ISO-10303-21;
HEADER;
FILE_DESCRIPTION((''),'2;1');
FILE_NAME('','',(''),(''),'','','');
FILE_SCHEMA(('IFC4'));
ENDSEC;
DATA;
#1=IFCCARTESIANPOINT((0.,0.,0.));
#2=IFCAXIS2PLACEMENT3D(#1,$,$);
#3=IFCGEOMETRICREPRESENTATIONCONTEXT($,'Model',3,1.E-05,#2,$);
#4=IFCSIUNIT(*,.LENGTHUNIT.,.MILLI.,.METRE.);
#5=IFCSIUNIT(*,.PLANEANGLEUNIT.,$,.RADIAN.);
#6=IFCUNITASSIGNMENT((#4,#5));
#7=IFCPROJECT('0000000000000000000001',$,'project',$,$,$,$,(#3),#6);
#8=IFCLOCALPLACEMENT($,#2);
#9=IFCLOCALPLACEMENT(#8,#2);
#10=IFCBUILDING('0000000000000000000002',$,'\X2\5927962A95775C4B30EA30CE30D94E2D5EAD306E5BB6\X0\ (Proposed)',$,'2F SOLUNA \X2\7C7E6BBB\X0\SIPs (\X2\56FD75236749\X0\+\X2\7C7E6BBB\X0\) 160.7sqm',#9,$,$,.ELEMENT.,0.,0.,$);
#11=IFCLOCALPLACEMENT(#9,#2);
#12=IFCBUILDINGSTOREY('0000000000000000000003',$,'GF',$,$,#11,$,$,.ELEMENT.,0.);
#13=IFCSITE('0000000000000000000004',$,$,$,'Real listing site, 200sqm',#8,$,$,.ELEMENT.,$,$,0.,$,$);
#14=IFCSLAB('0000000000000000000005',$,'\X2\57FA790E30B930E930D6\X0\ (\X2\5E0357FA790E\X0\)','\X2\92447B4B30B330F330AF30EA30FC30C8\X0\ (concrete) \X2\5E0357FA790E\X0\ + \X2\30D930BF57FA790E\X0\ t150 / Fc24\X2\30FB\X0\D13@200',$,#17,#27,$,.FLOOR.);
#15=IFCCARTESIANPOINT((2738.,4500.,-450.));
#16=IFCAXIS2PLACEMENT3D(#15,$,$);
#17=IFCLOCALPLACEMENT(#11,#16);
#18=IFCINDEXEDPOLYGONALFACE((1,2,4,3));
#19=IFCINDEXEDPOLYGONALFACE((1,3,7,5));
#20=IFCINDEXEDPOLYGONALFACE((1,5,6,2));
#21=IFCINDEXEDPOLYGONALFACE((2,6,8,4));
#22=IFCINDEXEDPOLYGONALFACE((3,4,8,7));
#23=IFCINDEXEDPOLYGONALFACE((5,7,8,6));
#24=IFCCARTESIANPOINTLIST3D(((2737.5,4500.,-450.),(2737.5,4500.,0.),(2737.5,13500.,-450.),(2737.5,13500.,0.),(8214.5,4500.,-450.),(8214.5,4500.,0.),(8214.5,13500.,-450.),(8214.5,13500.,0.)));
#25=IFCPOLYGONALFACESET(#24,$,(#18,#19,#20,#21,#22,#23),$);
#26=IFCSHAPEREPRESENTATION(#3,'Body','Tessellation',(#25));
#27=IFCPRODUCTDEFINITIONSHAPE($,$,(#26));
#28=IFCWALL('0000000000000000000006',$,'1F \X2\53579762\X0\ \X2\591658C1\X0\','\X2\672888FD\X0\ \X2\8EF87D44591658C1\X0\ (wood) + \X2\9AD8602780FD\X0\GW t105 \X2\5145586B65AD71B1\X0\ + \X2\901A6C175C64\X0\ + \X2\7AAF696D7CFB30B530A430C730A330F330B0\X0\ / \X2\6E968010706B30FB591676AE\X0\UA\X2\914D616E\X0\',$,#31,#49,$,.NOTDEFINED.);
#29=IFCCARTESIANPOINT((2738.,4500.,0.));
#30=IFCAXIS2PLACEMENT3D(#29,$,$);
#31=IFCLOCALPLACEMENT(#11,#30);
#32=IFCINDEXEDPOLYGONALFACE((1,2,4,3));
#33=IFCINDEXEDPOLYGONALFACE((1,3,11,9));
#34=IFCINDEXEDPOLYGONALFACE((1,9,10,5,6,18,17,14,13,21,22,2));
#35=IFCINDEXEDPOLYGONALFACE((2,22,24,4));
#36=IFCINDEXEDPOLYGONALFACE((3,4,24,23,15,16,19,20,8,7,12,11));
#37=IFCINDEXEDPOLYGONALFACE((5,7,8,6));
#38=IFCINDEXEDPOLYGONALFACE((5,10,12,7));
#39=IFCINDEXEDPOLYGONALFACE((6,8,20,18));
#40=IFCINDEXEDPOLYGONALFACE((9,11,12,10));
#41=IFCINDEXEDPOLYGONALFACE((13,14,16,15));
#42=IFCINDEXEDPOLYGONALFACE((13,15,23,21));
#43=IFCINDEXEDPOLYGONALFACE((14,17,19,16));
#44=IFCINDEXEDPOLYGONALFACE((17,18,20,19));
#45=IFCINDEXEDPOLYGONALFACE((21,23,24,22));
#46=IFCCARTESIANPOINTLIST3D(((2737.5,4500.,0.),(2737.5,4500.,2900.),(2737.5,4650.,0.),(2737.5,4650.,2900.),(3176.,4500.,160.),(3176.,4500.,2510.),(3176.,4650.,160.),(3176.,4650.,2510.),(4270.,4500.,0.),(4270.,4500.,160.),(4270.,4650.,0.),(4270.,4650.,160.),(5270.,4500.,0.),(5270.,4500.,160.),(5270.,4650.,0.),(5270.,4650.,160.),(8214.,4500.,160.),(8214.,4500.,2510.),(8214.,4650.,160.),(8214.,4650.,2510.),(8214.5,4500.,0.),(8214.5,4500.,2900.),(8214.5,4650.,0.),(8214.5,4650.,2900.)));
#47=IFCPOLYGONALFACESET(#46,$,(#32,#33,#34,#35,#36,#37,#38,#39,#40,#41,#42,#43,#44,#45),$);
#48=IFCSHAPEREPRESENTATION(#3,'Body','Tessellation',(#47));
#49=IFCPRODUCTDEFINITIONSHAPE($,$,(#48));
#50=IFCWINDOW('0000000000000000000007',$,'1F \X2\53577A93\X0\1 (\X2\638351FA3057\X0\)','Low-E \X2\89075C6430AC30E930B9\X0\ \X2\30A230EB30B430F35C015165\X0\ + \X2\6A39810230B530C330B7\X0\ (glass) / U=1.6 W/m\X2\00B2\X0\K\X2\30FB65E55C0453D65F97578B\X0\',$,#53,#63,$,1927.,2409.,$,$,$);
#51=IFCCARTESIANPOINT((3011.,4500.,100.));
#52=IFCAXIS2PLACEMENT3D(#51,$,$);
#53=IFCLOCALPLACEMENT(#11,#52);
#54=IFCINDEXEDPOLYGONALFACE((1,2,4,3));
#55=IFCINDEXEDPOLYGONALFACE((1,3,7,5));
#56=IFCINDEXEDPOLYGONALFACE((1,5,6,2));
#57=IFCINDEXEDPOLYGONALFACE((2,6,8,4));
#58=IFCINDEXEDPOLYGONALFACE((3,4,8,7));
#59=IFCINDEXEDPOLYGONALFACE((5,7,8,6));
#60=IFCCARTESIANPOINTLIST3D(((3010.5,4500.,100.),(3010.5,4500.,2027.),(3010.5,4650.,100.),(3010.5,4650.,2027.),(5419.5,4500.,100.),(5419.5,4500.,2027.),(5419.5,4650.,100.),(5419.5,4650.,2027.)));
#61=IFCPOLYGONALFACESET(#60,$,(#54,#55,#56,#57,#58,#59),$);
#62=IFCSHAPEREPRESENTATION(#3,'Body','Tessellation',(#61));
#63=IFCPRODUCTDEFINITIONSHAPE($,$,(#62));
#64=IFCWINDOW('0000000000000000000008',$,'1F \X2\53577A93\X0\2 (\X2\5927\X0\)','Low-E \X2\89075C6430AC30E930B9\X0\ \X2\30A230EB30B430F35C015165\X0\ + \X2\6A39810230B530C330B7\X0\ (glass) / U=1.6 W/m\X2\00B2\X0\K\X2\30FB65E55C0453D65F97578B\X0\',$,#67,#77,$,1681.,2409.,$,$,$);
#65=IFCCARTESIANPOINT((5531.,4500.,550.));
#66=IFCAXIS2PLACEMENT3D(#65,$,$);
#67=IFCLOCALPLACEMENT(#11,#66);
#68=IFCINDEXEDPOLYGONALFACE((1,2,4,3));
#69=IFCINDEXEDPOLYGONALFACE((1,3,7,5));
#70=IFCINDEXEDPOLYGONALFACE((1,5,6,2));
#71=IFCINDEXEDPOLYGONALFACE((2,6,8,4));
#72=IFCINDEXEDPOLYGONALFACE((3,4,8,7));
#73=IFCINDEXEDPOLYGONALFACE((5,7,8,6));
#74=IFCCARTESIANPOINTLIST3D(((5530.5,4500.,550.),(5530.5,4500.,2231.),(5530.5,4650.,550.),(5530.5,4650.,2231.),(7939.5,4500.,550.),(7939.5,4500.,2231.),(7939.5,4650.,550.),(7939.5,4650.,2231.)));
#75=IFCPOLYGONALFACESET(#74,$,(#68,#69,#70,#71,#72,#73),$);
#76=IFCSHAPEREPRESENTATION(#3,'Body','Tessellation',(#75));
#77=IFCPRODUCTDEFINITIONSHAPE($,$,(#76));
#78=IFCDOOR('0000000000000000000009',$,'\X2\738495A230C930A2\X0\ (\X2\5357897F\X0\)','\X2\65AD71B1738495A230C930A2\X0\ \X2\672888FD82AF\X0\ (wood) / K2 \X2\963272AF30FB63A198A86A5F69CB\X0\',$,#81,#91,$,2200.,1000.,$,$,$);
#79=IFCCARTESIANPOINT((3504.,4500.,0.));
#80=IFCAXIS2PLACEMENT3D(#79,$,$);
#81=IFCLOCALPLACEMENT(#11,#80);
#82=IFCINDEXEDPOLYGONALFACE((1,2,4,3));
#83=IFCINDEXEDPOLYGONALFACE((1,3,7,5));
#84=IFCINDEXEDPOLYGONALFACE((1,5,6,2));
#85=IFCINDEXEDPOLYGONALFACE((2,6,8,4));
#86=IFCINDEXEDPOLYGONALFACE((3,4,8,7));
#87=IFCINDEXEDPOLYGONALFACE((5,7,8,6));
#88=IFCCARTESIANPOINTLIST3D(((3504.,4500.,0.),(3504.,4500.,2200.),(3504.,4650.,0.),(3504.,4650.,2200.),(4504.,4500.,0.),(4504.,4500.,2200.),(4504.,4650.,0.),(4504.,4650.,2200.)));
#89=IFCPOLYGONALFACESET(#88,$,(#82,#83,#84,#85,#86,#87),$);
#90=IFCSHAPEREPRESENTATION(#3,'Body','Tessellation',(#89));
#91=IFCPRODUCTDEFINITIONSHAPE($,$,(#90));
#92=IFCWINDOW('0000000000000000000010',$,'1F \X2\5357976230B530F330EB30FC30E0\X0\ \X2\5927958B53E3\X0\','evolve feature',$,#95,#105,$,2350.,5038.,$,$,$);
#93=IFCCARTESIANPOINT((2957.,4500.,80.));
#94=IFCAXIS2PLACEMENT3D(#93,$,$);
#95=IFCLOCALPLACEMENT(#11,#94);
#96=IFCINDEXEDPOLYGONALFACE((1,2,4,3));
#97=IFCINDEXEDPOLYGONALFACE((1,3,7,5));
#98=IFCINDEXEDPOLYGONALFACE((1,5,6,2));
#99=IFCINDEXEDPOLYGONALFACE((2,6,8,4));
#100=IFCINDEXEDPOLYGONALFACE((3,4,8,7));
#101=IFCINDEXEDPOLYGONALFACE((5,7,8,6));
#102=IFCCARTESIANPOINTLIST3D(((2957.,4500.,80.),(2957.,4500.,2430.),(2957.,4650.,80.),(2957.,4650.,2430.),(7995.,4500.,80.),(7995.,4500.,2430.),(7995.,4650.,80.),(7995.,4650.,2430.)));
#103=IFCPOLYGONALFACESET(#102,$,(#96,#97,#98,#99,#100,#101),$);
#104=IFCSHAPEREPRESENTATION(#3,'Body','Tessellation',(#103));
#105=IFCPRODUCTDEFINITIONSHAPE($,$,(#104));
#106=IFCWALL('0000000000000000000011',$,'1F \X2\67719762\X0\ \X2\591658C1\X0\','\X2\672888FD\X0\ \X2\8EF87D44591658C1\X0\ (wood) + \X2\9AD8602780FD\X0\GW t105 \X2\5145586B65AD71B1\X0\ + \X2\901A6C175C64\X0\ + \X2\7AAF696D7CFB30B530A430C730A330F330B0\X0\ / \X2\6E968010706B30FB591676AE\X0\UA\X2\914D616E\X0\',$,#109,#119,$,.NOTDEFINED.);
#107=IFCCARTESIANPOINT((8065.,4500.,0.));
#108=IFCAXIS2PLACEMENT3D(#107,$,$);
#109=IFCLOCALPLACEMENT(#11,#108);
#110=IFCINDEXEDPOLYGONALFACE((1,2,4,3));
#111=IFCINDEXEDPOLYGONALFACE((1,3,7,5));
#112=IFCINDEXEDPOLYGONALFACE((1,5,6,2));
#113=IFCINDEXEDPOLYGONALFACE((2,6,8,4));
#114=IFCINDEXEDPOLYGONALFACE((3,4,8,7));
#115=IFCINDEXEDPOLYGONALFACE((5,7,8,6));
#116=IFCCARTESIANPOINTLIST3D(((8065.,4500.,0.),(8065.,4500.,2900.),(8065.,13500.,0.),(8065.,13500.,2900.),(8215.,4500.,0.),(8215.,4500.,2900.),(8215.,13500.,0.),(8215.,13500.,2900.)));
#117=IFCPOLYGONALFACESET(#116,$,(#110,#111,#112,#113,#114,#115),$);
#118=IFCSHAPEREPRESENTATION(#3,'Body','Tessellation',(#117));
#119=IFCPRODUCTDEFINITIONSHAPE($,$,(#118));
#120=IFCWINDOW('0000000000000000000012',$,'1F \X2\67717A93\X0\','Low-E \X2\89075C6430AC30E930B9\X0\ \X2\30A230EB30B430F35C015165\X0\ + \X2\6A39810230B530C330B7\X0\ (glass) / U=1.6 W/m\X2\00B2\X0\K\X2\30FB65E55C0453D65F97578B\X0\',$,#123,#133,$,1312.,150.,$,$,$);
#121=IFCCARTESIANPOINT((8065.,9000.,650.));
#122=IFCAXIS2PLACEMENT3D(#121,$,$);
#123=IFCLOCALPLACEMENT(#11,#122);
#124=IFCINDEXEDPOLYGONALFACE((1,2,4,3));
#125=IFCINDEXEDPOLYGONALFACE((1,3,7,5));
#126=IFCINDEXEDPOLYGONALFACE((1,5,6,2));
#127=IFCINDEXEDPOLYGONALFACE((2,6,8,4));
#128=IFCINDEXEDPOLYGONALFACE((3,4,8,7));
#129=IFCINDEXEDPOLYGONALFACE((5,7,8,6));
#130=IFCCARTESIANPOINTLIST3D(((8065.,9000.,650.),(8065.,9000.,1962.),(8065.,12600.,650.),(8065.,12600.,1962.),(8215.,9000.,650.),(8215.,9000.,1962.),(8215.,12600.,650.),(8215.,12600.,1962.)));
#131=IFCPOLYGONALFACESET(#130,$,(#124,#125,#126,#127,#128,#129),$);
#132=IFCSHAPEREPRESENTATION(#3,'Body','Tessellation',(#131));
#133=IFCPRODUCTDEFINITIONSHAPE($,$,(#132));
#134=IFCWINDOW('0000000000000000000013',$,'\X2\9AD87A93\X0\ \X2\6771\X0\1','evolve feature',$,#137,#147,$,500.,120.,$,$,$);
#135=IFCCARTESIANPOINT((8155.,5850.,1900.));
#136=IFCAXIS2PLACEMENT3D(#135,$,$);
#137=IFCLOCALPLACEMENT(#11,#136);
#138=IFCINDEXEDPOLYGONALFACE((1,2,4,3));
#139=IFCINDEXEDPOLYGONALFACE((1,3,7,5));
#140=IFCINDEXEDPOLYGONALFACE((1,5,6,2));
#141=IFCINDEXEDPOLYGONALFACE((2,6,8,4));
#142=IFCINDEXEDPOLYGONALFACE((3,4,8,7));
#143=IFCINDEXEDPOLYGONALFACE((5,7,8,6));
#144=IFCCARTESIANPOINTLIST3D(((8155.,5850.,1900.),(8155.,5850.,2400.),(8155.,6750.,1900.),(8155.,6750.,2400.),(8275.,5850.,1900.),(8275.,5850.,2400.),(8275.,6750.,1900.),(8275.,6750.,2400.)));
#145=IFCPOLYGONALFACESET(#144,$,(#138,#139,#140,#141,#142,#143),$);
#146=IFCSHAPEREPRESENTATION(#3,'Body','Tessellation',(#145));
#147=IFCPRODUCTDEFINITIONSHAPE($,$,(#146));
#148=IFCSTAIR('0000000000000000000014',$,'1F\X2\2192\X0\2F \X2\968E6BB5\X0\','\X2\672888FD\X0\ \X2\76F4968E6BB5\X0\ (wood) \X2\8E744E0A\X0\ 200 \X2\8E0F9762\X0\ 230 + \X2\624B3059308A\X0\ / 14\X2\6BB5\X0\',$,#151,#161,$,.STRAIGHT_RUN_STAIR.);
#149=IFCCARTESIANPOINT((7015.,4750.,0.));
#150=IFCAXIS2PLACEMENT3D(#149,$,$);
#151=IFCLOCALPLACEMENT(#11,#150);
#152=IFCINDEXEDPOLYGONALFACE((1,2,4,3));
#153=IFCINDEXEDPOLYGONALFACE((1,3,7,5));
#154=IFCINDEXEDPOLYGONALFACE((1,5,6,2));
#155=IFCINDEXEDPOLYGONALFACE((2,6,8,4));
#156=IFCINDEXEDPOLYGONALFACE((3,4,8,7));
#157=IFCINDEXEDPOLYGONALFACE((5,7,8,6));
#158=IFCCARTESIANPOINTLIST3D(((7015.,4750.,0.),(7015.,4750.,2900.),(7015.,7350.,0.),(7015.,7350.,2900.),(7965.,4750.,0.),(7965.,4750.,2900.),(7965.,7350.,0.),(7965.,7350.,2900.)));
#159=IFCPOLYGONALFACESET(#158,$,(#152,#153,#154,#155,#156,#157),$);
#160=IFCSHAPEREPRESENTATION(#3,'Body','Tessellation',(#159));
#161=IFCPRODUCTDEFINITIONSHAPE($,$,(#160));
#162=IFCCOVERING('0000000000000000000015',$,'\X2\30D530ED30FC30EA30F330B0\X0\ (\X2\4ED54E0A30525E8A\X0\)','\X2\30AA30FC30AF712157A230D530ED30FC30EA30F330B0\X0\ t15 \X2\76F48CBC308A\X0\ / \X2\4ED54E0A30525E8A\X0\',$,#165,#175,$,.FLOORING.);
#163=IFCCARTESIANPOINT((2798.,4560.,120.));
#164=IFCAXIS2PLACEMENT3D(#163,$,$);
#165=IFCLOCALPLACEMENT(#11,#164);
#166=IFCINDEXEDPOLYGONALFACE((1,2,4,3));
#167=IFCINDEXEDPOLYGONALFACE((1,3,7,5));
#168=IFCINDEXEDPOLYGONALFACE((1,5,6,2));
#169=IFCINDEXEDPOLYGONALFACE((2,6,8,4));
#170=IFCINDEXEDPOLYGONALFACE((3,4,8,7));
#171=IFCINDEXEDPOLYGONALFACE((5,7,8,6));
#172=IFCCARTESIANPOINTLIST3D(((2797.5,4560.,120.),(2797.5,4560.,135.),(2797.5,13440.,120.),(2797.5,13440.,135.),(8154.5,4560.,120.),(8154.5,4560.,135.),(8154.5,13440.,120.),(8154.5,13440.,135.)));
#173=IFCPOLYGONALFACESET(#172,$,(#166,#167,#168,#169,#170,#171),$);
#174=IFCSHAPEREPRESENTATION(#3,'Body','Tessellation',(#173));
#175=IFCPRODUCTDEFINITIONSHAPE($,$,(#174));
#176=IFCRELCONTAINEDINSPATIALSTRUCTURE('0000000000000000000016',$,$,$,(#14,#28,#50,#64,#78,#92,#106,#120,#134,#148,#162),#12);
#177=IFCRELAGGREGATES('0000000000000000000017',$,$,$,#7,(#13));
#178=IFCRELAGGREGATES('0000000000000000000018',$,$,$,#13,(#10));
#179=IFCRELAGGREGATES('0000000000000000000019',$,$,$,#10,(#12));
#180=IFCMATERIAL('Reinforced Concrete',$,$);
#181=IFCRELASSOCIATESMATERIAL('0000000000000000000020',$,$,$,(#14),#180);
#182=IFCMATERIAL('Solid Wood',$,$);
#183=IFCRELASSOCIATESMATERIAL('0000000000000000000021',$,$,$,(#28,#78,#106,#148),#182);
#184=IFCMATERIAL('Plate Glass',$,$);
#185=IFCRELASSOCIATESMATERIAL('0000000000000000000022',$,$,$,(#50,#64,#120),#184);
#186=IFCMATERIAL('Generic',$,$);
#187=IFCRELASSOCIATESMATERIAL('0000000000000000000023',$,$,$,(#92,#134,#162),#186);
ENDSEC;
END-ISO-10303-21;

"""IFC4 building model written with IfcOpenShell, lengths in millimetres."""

from ifc_helpers import new_model, si_unit, frame, frame_2d, origin, place, context, project, spatial, rectangle, extrude, material, element, fill, save


model = new_model("IFC4")

# Units and contexts
model_context = context("Model", 3, precision=1e-05, world=origin())
ifc_project = project(units=[si_unit("LENGTHUNIT", "METRE", prefix="MILLI"), si_unit("PLANEANGLEUNIT", "RADIAN")], contexts=[model_context])

# Site, building, storey
site_placement = place(None, origin())
site = spatial("IfcSite", under=ifc_project, at=site_placement, ObjectType="Real listing site, 200sqm", CompositionType="ELEMENT", RefElevation=0.0)
building_placement = place(site_placement, origin())
building = spatial("IfcBuilding", under=site, at=building_placement, Name="大阪長屋リノベ中庭の家 (Proposed)", ObjectType="2F SOLUNA 籾殻SIPs (国産杉+籾殻) 160.7sqm", CompositionType="ELEMENT", ElevationOfRefHeight=0.0, ElevationOfTerrain=0.0)
storey_placement = place(building_placement, origin())
storey = spatial("IfcBuildingStorey", under=building, at=storey_placement, Name="GF", CompositionType="ELEMENT", Elevation=0.0)

# Slab
ifc_material_1 = material(Name="Reinforced Concrete")
slab_1_placement = place(storey_placement, frame((2738.0, 4500.0, -450.0)))
element("IfcSlab", 1, at=slab_1_placement, inside=storey, material=ifc_material_1, Name="基礎スラブ (布基礎)", Description="鉄筋コンクリート (concrete) 布基礎 + ベタ基礎 t150 / Fc24・D13@200", PredefinedType="FLOOR", context=model_context, shape_type="SweptSolid", body=[
    extrude(rectangle(XDim=5477.0, YDim=9000.0, at=frame_2d((2738.0, 4500.0))), frame((2738.0, 4500.0, -450.0)), (0.0, 0.0, 1.0), 450.0),
])
ifc_material_2 = material(Name="Solid Wood")
ifc_material_3 = material(Name="Generic")

# Wall, openings, windows, door
wall_1_placement = place(storey_placement, frame((2738.0, 4500.0, 0.0)))
wall_1 = element("IfcWall", 2, at=wall_1_placement, inside=storey, material=ifc_material_2, Name="1F 南面 外壁", Description="木製 軸組外壁 (wood) + 高性能GW t105 充填断熱 + 通気層 + 窯業系サイディング / 準耐火・外皮UA配慮", PredefinedType="NOTDEFINED", context=model_context, shape_type="SweptSolid", body=[
    extrude(rectangle(XDim=5477.0, YDim=150.0, at=frame_2d((2738.0, 75.0))), frame((2738.0, 4500.0, 0.0)), (0.0, 0.0, 1.0), 2900.0),
])
opening_1_placement = place(storey_placement, frame((3011.0, 4500.0, 100.0)))
opening_1 = element("IfcOpeningElement", 3, at=opening_1_placement, cuts=wall_1, PredefinedType="NOTDEFINED", context=model_context, shape_type="SweptSolid", body=[
    extrude(rectangle(XDim=2409.0, YDim=150.0, at=frame_2d((1204.0, 75.0))), frame((3011.0, 4500.0, 100.0)), (0.0, 0.0, 1.0), 1927.0),
])
opening_2_placement = place(storey_placement, frame((5531.0, 4500.0, 550.0)))
opening_2 = element("IfcOpeningElement", 4, at=opening_2_placement, cuts=wall_1, PredefinedType="NOTDEFINED", context=model_context, shape_type="SweptSolid", body=[
    extrude(rectangle(XDim=2409.0, YDim=150.0, at=frame_2d((1204.0, 75.0))), frame((5531.0, 4500.0, 550.0)), (0.0, 0.0, 1.0), 1681.0),
])
opening_3_placement = place(storey_placement, frame((3504.0, 4500.0, 0.0)))
opening_3 = element("IfcOpeningElement", 5, at=opening_3_placement, cuts=wall_1, PredefinedType="NOTDEFINED", context=model_context, shape_type="SweptSolid", body=[
    extrude(rectangle(XDim=1000.0, YDim=150.0, at=frame_2d((500.0, 75.0))), frame((3504.0, 4500.0, 0.0)), (0.0, 0.0, 1.0), 2200.0),
])
opening_4_placement = place(storey_placement, frame((2957.0, 4500.0, 80.0)))
opening_4 = element("IfcOpeningElement", 6, at=opening_4_placement, cuts=wall_1, PredefinedType="NOTDEFINED", context=model_context, shape_type="SweptSolid", body=[
    extrude(rectangle(XDim=5038.0, YDim=150.0, at=frame_2d((2519.0, 75.0))), frame((2957.0, 4500.0, 80.0)), (0.0, 0.0, 1.0), 2350.0),
])
ifc_material_4 = material(Name="Plate Glass")
window_1_placement = place(storey_placement, frame((3011.0, 4500.0, 100.0)))
window_1 = element("IfcWindow", 7, at=window_1_placement, inside=storey, material=ifc_material_4, Name="1F 南窓1 (掃出し)", Description="Low-E 複層ガラス アルゴン封入 + 樹脂サッシ (glass) / U=1.6 W/m²K・日射取得型", OverallHeight=1927.0, OverallWidth=2409.0, context=model_context, shape_type="SweptSolid", body=[
    extrude(rectangle(XDim=2409.0, YDim=150.0, at=frame_2d((1204.0, 75.0))), frame((3011.0, 4500.0, 100.0)), (0.0, 0.0, 1.0), 1927.0),
])
fill(opening_1, window_1)
window_2_placement = place(storey_placement, frame((5531.0, 4500.0, 550.0)))
window_2 = element("IfcWindow", 8, at=window_2_placement, inside=storey, material=ifc_material_4, Name="1F 南窓2 (大)", Description="Low-E 複層ガラス アルゴン封入 + 樹脂サッシ (glass) / U=1.6 W/m²K・日射取得型", OverallHeight=1681.0, OverallWidth=2409.0, context=model_context, shape_type="SweptSolid", body=[
    extrude(rectangle(XDim=2409.0, YDim=150.0, at=frame_2d((1204.0, 75.0))), frame((5531.0, 4500.0, 550.0)), (0.0, 0.0, 1.0), 1681.0),
])
fill(opening_2, window_2)
door_placement = place(storey_placement, frame((3504.0, 4500.0, 0.0)))
door = element("IfcDoor", 9, at=door_placement, inside=storey, material=ifc_material_2, Name="玄関ドア (南西)", Description="断熱玄関ドア 木製芯 (wood) / K2 防犯・採風機構", OverallHeight=2200.0, OverallWidth=1000.0, context=model_context, shape_type="SweptSolid", body=[
    extrude(rectangle(XDim=1000.0, YDim=150.0, at=frame_2d((500.0, 75.0))), frame((3504.0, 4500.0, 0.0)), (0.0, 0.0, 1.0), 2200.0),
])
fill(opening_3, door)
window_3_placement = place(storey_placement, frame((2957.0, 4500.0, 80.0)))
window_3 = element("IfcWindow", 10, at=window_3_placement, inside=storey, material=ifc_material_3, Name="1F 南面サンルーム 大開口", Description="evolve feature", OverallHeight=2350.0, OverallWidth=5038.0, context=model_context, shape_type="SweptSolid", body=[
    extrude(rectangle(XDim=5038.0, YDim=150.0, at=frame_2d((2519.0, 75.0))), frame((2957.0, 4500.0, 80.0)), (0.0, 0.0, 1.0), 2350.0),
])
fill(opening_4, window_3)

# Wall, openings, windows
wall_2_placement = place(storey_placement, frame((8065.0, 4500.0, 0.0)))
wall_2 = element("IfcWall", 11, at=wall_2_placement, inside=storey, material=ifc_material_2, Name="1F 東面 外壁", Description="木製 軸組外壁 (wood) + 高性能GW t105 充填断熱 + 通気層 + 窯業系サイディング / 準耐火・外皮UA配慮", PredefinedType="NOTDEFINED", context=model_context, shape_type="SweptSolid", body=[
    extrude(rectangle(XDim=150.0, YDim=9000.0, at=frame_2d((75.0, 4500.0))), frame((8065.0, 4500.0, 0.0)), (0.0, 0.0, 1.0), 2900.0),
])
opening_5_placement = place(storey_placement, frame((8065.0, 9000.0, 650.0)))
opening_5 = element("IfcOpeningElement", 12, at=opening_5_placement, cuts=wall_2, PredefinedType="NOTDEFINED", context=model_context, shape_type="SweptSolid", body=[
    extrude(rectangle(XDim=150.0, YDim=3600.0, at=frame_2d((75.0, 1800.0))), frame((8065.0, 9000.0, 650.0)), (0.0, 0.0, 1.0), 1312.0),
])
opening_6_placement = place(storey_placement, frame((8155.0, 5850.0, 1900.0)))
opening_6 = element("IfcOpeningElement", 13, at=opening_6_placement, cuts=wall_2, PredefinedType="NOTDEFINED", context=model_context, shape_type="SweptSolid", body=[
    extrude(rectangle(XDim=120.0, YDim=900.0, at=frame_2d((60.0, 450.0))), frame((8155.0, 5850.0, 1900.0)), (0.0, 0.0, 1.0), 500.0),
])
window_4_placement = place(storey_placement, frame((8065.0, 9000.0, 650.0)))
window_4 = element("IfcWindow", 14, at=window_4_placement, inside=storey, material=ifc_material_4, Name="1F 東窓", Description="Low-E 複層ガラス アルゴン封入 + 樹脂サッシ (glass) / U=1.6 W/m²K・日射取得型", OverallHeight=1312.0, OverallWidth=150.0, context=model_context, shape_type="SweptSolid", body=[
    extrude(rectangle(XDim=150.0, YDim=3600.0, at=frame_2d((75.0, 1800.0))), frame((8065.0, 9000.0, 650.0)), (0.0, 0.0, 1.0), 1312.0),
])
fill(opening_5, window_4)
window_5_placement = place(storey_placement, frame((8155.0, 5850.0, 1900.0)))
window_5 = element("IfcWindow", 15, at=window_5_placement, inside=storey, material=ifc_material_3, Name="高窓 東1", Description="evolve feature", OverallHeight=500.0, OverallWidth=120.0, context=model_context, shape_type="SweptSolid", body=[
    extrude(rectangle(XDim=120.0, YDim=900.0, at=frame_2d((60.0, 450.0))), frame((8155.0, 5850.0, 1900.0)), (0.0, 0.0, 1.0), 500.0),
])
fill(opening_6, window_5)

# Stair
stair_placement = place(storey_placement, frame((7015.0, 4750.0, 0.0)))
element("IfcStair", 16, at=stair_placement, inside=storey, material=ifc_material_2, Name="1F→2F 階段", Description="木製 直階段 (wood) 蹴上 200 踏面 230 + 手すり / 14段", PredefinedType="STRAIGHT_RUN_STAIR", context=model_context, shape_type="SweptSolid", body=[
    extrude(rectangle(XDim=950.0, YDim=2600.0, at=frame_2d((475.0, 1300.0))), frame((7015.0, 4750.0, 0.0)), (0.0, 0.0, 1.0), 2900.0),
])

# Covering
covering_placement = place(storey_placement, frame((2798.0, 4560.0, 120.0)))
element("IfcCovering", 17, at=covering_placement, inside=storey, material=ifc_material_3, Name="フローリング (仕上げ床)", Description="オーク無垢フローリング t15 直貼り / 仕上げ床", PredefinedType="FLOORING", context=model_context, shape_type="SweptSolid", body=[
    extrude(rectangle(XDim=5357.0, YDim=8880.0, at=frame_2d((2678.0, 4440.0))), frame((2798.0, 4560.0, 120.0)), (0.0, 0.0, 1.0), 15.0),
])

save(model, "model.ifc")
